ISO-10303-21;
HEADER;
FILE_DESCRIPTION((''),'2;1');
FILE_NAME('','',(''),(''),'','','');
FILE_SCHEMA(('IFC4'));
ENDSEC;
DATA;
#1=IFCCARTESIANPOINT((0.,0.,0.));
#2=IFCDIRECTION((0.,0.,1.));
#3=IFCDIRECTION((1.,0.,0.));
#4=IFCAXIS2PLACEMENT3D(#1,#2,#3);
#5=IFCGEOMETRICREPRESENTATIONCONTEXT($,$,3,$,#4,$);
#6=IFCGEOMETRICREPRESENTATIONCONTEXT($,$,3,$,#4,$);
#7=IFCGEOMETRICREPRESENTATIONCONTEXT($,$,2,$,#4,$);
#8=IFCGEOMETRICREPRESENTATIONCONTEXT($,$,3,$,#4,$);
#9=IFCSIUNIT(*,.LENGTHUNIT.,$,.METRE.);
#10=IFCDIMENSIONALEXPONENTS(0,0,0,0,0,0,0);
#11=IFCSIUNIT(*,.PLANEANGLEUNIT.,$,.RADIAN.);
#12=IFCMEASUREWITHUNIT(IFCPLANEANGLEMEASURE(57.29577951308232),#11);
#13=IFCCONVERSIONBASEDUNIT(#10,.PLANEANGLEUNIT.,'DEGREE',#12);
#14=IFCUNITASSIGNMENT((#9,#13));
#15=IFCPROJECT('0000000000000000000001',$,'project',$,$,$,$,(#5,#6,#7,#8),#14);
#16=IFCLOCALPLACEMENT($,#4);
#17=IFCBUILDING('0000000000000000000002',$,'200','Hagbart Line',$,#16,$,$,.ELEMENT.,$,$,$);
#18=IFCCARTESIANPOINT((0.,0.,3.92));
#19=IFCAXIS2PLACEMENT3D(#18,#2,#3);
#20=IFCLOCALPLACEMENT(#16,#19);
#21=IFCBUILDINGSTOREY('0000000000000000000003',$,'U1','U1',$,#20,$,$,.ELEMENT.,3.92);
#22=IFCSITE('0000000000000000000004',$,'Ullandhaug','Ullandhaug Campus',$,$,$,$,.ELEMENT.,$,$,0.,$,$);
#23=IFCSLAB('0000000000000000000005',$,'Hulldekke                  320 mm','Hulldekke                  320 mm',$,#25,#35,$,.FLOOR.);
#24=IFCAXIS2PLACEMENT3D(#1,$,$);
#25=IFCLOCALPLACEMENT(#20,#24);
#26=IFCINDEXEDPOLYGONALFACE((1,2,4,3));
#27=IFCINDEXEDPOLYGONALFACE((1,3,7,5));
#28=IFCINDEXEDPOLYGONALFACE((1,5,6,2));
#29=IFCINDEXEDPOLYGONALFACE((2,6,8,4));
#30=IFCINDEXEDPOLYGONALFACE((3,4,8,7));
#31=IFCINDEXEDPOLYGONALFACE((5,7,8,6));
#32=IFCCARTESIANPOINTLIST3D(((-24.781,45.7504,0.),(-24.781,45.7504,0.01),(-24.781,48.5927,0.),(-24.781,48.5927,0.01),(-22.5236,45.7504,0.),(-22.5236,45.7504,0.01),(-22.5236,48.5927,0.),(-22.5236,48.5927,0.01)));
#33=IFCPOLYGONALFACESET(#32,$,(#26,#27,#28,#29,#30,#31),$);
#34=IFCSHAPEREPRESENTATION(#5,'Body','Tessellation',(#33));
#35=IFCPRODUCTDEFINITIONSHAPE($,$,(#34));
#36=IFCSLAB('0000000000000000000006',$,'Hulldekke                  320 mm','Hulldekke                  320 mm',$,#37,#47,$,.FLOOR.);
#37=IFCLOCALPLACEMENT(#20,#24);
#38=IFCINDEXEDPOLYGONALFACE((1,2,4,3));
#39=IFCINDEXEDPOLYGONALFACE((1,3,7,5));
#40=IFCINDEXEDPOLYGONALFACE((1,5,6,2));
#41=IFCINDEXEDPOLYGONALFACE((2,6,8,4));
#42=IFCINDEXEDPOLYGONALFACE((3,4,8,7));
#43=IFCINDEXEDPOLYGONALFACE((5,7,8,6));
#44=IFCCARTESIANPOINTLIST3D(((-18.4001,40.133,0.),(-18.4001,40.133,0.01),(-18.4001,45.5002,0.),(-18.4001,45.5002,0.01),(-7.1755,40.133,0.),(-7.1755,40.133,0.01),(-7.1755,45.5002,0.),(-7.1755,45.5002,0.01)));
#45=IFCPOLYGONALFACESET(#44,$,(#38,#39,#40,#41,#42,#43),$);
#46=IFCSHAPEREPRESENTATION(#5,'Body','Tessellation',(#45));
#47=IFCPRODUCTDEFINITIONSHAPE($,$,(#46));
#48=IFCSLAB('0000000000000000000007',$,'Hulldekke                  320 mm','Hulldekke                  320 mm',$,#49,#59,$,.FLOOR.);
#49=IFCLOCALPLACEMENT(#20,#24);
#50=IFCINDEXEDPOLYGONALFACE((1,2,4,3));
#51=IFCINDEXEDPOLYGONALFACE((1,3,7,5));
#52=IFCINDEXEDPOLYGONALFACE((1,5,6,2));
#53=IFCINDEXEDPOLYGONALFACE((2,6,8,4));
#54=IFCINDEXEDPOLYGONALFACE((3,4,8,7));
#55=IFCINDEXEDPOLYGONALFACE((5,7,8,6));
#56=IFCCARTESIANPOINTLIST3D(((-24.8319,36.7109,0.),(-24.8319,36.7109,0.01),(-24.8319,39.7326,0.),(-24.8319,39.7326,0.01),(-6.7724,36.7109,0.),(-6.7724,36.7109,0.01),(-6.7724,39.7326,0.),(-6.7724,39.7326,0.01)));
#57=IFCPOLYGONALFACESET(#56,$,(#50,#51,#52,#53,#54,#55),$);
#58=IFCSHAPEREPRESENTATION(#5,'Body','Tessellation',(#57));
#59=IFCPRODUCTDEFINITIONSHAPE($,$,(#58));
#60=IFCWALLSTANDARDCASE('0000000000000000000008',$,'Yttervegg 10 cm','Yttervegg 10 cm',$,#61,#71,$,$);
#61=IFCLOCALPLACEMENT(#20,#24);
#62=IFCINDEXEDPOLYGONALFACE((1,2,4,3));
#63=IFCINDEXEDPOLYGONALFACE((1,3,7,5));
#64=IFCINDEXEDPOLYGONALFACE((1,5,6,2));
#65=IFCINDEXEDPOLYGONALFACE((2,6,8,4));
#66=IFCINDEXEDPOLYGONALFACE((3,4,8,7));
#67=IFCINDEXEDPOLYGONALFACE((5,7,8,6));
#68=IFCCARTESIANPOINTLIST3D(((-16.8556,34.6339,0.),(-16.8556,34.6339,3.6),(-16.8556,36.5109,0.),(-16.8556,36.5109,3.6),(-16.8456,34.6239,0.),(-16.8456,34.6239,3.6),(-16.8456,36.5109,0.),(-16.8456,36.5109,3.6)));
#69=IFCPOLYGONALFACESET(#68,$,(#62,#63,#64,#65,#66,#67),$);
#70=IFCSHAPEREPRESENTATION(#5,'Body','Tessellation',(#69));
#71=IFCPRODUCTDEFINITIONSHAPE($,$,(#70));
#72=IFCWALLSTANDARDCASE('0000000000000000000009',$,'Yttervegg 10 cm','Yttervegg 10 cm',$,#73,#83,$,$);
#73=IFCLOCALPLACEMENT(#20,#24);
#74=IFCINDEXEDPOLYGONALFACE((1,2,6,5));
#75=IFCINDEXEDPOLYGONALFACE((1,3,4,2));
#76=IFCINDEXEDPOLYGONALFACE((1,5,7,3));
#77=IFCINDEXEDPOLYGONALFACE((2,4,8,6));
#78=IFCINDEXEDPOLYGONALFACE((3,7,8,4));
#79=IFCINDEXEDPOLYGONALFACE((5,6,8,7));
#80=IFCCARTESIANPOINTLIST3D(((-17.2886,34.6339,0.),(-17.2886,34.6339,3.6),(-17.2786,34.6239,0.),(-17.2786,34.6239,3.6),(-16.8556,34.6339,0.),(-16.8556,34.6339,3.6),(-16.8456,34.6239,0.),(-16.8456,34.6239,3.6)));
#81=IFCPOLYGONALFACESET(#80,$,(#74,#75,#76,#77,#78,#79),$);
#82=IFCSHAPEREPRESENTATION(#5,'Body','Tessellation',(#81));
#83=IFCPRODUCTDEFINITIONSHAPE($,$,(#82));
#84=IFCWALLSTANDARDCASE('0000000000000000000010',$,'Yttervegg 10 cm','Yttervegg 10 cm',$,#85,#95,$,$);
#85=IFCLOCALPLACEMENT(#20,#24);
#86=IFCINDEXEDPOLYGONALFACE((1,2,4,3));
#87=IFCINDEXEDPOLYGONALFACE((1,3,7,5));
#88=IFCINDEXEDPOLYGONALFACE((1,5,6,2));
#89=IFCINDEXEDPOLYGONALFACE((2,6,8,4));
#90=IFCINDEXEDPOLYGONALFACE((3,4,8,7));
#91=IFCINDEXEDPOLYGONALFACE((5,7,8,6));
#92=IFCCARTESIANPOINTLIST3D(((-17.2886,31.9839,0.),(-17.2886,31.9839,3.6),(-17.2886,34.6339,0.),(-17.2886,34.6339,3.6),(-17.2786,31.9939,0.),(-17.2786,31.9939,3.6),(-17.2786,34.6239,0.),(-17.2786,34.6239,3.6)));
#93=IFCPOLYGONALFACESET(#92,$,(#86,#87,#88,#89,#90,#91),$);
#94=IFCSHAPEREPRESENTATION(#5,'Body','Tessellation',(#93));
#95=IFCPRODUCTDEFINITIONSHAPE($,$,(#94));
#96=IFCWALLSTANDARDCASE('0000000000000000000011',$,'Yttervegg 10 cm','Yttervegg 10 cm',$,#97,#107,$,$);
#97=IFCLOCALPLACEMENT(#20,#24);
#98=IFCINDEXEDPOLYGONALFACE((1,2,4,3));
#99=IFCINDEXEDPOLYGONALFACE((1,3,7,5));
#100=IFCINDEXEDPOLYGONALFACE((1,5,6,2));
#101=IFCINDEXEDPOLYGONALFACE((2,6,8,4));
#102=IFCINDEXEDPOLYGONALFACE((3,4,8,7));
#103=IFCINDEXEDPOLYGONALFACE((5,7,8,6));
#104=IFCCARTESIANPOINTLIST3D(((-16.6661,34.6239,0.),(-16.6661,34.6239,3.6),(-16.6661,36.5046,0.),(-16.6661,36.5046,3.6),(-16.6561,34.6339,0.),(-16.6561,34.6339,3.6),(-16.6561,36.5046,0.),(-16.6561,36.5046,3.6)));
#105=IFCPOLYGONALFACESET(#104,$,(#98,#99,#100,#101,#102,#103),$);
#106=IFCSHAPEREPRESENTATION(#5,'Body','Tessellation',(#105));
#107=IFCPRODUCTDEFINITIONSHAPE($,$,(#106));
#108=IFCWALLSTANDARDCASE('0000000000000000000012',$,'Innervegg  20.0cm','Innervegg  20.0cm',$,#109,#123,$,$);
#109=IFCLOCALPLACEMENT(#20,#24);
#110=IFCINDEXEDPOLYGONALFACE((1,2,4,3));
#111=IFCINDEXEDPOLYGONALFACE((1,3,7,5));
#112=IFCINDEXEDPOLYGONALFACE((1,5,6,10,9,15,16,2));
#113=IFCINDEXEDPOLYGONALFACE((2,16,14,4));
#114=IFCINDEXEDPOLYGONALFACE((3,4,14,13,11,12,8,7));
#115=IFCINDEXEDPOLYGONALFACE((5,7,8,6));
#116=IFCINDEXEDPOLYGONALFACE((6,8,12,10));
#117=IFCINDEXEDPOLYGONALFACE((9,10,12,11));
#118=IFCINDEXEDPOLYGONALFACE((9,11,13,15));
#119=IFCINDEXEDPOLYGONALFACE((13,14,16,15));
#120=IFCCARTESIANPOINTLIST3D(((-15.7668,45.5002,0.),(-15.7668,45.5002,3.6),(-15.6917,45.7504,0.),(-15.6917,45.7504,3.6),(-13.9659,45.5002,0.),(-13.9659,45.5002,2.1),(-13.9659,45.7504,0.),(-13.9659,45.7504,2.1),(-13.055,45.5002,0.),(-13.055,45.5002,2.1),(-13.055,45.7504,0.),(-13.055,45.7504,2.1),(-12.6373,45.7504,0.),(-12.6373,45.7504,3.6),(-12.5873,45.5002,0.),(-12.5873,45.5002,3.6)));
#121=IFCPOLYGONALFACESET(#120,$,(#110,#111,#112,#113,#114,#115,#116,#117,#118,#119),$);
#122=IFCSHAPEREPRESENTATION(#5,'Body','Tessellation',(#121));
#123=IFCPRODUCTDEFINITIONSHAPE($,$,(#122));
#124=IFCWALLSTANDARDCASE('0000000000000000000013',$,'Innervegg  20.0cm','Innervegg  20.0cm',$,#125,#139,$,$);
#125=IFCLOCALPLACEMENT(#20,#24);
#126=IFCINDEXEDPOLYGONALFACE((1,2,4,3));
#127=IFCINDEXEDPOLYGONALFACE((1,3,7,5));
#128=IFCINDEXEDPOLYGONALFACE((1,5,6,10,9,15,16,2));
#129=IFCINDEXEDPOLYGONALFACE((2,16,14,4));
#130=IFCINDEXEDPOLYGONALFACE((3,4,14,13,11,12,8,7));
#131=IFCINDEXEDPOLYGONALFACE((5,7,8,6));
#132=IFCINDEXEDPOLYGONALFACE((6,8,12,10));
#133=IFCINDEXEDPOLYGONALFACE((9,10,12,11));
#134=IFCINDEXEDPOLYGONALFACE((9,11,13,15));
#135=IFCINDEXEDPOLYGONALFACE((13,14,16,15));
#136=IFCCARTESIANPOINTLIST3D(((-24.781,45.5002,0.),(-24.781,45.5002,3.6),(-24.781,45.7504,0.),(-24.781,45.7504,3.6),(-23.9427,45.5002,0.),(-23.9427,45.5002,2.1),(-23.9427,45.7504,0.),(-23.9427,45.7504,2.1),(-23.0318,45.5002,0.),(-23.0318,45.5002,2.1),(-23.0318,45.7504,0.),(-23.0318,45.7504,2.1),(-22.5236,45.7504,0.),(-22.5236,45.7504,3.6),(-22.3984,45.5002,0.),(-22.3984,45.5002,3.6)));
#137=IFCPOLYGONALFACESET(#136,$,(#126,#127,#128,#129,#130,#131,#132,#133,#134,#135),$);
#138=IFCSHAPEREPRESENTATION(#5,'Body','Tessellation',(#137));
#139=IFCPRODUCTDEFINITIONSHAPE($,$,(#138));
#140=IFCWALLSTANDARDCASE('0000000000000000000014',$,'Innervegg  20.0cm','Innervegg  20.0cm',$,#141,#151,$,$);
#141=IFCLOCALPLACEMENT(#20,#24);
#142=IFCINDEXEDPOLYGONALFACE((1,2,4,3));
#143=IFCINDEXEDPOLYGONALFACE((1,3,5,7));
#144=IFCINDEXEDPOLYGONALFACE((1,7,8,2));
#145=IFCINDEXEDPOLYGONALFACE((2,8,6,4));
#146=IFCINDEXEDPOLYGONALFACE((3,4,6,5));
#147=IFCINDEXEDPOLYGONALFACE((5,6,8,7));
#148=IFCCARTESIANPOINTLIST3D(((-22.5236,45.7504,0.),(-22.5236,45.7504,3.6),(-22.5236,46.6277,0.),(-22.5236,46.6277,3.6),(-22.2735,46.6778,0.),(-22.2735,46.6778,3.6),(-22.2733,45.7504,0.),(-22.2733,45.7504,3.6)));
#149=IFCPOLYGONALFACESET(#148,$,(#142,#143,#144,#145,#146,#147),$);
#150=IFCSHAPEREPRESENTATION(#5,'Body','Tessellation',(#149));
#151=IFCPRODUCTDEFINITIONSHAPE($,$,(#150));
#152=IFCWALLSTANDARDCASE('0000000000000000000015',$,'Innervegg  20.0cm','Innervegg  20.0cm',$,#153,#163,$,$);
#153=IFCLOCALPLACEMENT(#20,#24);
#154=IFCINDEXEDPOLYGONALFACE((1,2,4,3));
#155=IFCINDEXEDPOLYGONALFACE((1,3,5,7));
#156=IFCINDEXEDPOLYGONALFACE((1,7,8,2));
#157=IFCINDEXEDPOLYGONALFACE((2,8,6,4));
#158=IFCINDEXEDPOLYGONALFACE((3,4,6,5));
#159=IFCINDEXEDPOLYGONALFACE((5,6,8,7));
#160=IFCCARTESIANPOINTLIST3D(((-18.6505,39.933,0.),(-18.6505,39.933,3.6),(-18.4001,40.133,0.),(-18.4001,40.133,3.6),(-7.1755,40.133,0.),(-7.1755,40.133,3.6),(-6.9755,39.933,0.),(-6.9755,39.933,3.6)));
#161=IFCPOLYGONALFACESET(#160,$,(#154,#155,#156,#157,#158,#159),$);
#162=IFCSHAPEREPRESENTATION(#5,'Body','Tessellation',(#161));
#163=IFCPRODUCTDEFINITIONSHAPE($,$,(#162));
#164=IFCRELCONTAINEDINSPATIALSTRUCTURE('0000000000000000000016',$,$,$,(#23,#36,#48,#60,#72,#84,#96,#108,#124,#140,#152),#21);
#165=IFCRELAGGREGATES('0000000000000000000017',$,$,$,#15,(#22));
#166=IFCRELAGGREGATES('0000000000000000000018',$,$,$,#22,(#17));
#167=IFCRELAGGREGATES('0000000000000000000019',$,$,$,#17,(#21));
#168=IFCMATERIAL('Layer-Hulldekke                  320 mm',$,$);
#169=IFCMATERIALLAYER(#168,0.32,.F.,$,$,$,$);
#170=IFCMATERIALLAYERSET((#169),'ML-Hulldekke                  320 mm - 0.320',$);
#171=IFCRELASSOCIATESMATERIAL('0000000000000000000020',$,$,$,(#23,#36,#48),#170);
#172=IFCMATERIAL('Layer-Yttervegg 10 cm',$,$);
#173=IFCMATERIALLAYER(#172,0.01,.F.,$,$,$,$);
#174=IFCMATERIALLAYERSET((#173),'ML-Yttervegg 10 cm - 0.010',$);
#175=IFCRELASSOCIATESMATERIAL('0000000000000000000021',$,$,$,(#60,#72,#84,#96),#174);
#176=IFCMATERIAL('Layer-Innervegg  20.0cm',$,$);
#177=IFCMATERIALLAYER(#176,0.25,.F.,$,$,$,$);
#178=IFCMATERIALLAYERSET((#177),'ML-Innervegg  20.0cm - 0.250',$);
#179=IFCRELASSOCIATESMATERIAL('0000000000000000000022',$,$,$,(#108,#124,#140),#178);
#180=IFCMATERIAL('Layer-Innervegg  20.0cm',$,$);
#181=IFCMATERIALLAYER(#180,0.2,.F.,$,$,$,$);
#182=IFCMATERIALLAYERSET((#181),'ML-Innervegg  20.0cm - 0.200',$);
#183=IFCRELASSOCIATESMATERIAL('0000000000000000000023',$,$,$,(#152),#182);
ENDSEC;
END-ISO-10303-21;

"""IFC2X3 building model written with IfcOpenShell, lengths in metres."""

from ifc_helpers import new_model, entity, si_unit, converted_unit, frame, origin_with_axes, place, context, project, spatial, polyline, outline, extrude, material, layer, layer_set, layer_usage, element, save


model = new_model("IFC2X3")

# Units and contexts
context_of_model_1 = context(None, 3, world=origin_with_axes())
context_of_model_2 = context(None, 3, world=origin_with_axes())
context_of_model_3 = context(None, 2, world=origin_with_axes())
context_of_model_4 = context(None, 3, world=origin_with_axes())
ifc_project = project(units=[si_unit("LENGTHUNIT", "METRE"), converted_unit("PLANEANGLEUNIT", "DEGREE", entity("IfcPlaneAngleMeasure", 57.29577951308232), si_unit("PLANEANGLEUNIT", "RADIAN"), dimensions=[0, 0, 0, 0, 0, 0, 0])], contexts=[context_of_model_1, context_of_model_2, context_of_model_3, context_of_model_4])

# Site, building, storey
site = spatial("IfcSite", under=ifc_project, Name="Ullandhaug", Description="Ullandhaug Campus", CompositionType="ELEMENT", RefElevation=0.0)
building_placement = place(None, origin_with_axes())
building = spatial("IfcBuilding", under=site, at=building_placement, Name="200", Description="Hagbart Line", CompositionType="ELEMENT")
storey_placement = place(building_placement, frame((0.0, 0.0, 3.92), z_axis=(0.0, 0.0, 1.0), x_axis=(1.0, 0.0, 0.0)))
storey = spatial("IfcBuildingStorey", under=building, at=storey_placement, Name="U1", Description="U1", CompositionType="ELEMENT", Elevation=3.92)

# Slabs
ifc_material_1 = material(Name="Layer-Hulldekke                  320 mm")
ifc_layer_1 = layer(ifc_material_1, 0.32, ventilated=False)
ifc_layer_set_1 = layer_set([ifc_layer_1], Name="ML-Hulldekke                  320 mm - 0.320")
ifc_layer_usage_1 = layer_usage(ifc_layer_set_1, "AXIS2", "POSITIVE", 0.0)
slab_1_placement = place(storey_placement, frame((-24.781, 45.7504, 0.0), z_axis=(0.0, 0.0, 1.0), x_axis=(1.0, 0.0, 0.0)))
element("IfcSlab", 1, at=slab_1_placement, inside=storey, material=ifc_layer_usage_1, Name="Hulldekke                  320 mm", Description="Hulldekke                  320 mm", PredefinedType="FLOOR", context=context_of_model_1, shape_type="SweptSolid", body=[
    extrude(outline(polyline([(0.0, 0.0), (2.2574, 0.0), (2.2574, 2.8423), (0.0, 2.8423), (0.0, 0.0)])), origin_with_axes(), (0.0, 0.0, 1.0), 0.01),
])
slab_2_placement = place(storey_placement, frame((-18.4001, 40.133, 0.0), z_axis=(0.0, 0.0, 1.0), x_axis=(1.0, 0.0, 0.0)))
element("IfcSlab", 2, at=slab_2_placement, inside=storey, material=ifc_layer_usage_1, Name="Hulldekke                  320 mm", Description="Hulldekke                  320 mm", PredefinedType="FLOOR", context=context_of_model_1, shape_type="SweptSolid", body=[
    extrude(outline(polyline([(0.0, 0.0), (11.2246, 0.0), (11.2246, 5.3672), (0.0, 5.3672), (0.0, 0.0)])), origin_with_axes(), (0.0, 0.0, 1.0), 0.01),
])
slab_3_placement = place(storey_placement, frame((-24.8319, 36.7109, 0.0), z_axis=(0.0, 0.0, 1.0), x_axis=(1.0, 0.0, 0.0)))
element("IfcSlab", 3, at=slab_3_placement, inside=storey, material=ifc_layer_usage_1, Name="Hulldekke                  320 mm", Description="Hulldekke                  320 mm", PredefinedType="FLOOR", context=context_of_model_1, shape_type="SweptSolid", body=[
    extrude(outline(polyline([(0.0, 0.0), (18.0596, 0.0), (18.0596, 3.0216), (0.0, 3.0216), (0.0, 0.0)])), origin_with_axes(), (0.0, 0.0, 1.0), 0.01),
])

# Walls
ifc_material_2 = material(Name="Layer-Yttervegg 10 cm")
ifc_layer_2 = layer(ifc_material_2, 0.01, ventilated=False)
ifc_layer_set_2 = layer_set([ifc_layer_2], Name="ML-Yttervegg 10 cm - 0.010")
ifc_layer_usage_2 = layer_usage(ifc_layer_set_2, "AXIS2", "POSITIVE", 0.0)
wall_1_placement = place(storey_placement, frame((-16.8556, 36.5109, 0.0), z_axis=(0.0, 0.0, 1.0), x_axis=(0.0, -1.0, 0.0)))
element("IfcWallStandardCase", 4, at=wall_1_placement, inside=storey, material=ifc_layer_usage_2, Name="Yttervegg 10 cm", Description="Yttervegg 10 cm", context=context_of_model_1, shape_type="SweptSolid", body=[
    extrude(outline(polyline([(0.0, 0.0), (1.877, 0.0), (1.887, 0.01), (0.0, 0.01), (0.0, 0.0)])), frame((0.0, 0.0, 0.0), z_axis=(0.0, 0.0, 1.0), x_axis=(1.0, 0.0, 0.0)), (0.0, 0.0, 1.0), 3.6),
])
wall_2_placement = place(storey_placement, frame((-16.8556, 34.6339, 0.0), z_axis=(0.0, 0.0, 1.0), x_axis=(-1.0, 0.0, 0.0)))
element("IfcWallStandardCase", 5, at=wall_2_placement, inside=storey, material=ifc_layer_usage_2, Name="Yttervegg 10 cm", Description="Yttervegg 10 cm", context=context_of_model_1, shape_type="SweptSolid", body=[
    extrude(outline(polyline([(0.0, 0.0), (0.433, 0.0), (0.423, 0.01), (-0.01, 0.01), (0.0, 0.0)])), frame((0.0, 0.0, 0.0), z_axis=(0.0, 0.0, 1.0), x_axis=(1.0, 0.0, 0.0)), (0.0, 0.0, 1.0), 3.6),
])
wall_3_placement = place(storey_placement, frame((-17.2886, 34.6339, 0.0), z_axis=(0.0, 0.0, 1.0), x_axis=(0.0, -1.0, 0.0)))
element("IfcWallStandardCase", 6, at=wall_3_placement, inside=storey, material=ifc_layer_usage_2, Name="Yttervegg 10 cm", Description="Yttervegg 10 cm", context=context_of_model_1, shape_type="SweptSolid", body=[
    extrude(outline(polyline([(0.0, 0.0), (2.65, 0.0), (2.64, 0.01), (0.01, 0.01), (0.0, 0.0)])), frame((0.0, 0.0, 0.0), z_axis=(0.0, 0.0, 1.0), x_axis=(1.0, 0.0, 0.0)), (0.0, 0.0, 1.0), 3.6),
])
wall_4_placement = place(storey_placement, frame((-16.6561, 34.6339, 0.0), z_axis=(0.0, 0.0, 1.0), x_axis=(0.0, 1.0, 0.0)))
element("IfcWallStandardCase", 7, at=wall_4_placement, inside=storey, material=ifc_layer_usage_2, Name="Yttervegg 10 cm", Description="Yttervegg 10 cm", context=context_of_model_1, shape_type="SweptSolid", body=[
    extrude(outline(polyline([(0.0, 0.0), (1.8707, 0.0), (1.8707, 0.01), (-0.01, 0.01), (0.0, 0.0)])), frame((0.0, 0.0, 0.0), z_axis=(0.0, 0.0, 1.0), x_axis=(1.0, 0.0, 0.0)), (0.0, 0.0, 1.0), 3.6),
])

# Walls, openings
ifc_material_3 = material(Name="Layer-Innervegg  20.0cm")
ifc_layer_3 = layer(ifc_material_3, 0.25, ventilated=False)
ifc_layer_set_3 = layer_set([ifc_layer_3], Name="ML-Innervegg  20.0cm - 0.250")
ifc_layer_usage_3 = layer_usage(ifc_layer_set_3, "AXIS2", "POSITIVE", 0.0)
wall_5_placement = place(storey_placement, frame((-15.7668, 45.5002, 0.0), z_axis=(0.0, 0.0, 1.0), x_axis=(1.0, 0.0, 0.0)))
wall_5 = element("IfcWallStandardCase", 8, at=wall_5_placement, inside=storey, material=ifc_layer_usage_3, Name="Innervegg  20.0cm", Description="Innervegg  20.0cm", context=context_of_model_1, shape_type="SweptSolid", body=[
    extrude(outline(polyline([(0.0, 0.0), (3.1795, 0.0), (3.1294, 0.2502), (0.0751, 0.2502), (0.0, 0.0)])), origin_with_axes(), (0.0, 0.0, 1.0), 3.6),
])
opening_1_placement = place(wall_5_placement, frame((1.8009, 0.2502, 0.0), z_axis=(0.0, 0.0, 1.0), x_axis=(1.0, 0.0, 0.0)))
element("IfcOpeningElement", 9, at=opening_1_placement, cuts=wall_5, context=context_of_model_1, shape_type="SweptSolid", body=[
    extrude(outline(polyline([(0.0, 0.0), (2.1, 0.0), (2.1, 0.9109), (0.0, 0.9109), (0.0, 0.0)])), frame((0.0, 0.0, 0.0), z_axis=(0.0, 1.0, 0.0), x_axis=(0.0, 0.0, 1.0)), (0.0, 0.0, -1.0), 0.2502),
])
wall_6_placement = place(storey_placement, frame((-24.781, 45.5002, 0.0), z_axis=(0.0, 0.0, 1.0), x_axis=(1.0, 0.0, 0.0)))
wall_6 = element("IfcWallStandardCase", 10, at=wall_6_placement, inside=storey, material=ifc_layer_usage_3, Name="Innervegg  20.0cm", Description="Innervegg  20.0cm", context=context_of_model_1, shape_type="SweptSolid", body=[
    extrude(outline(polyline([(0.0, 0.0), (2.3826, 0.0), (2.2574, 0.2502), (0.0, 0.2502), (0.0, 0.0)])), origin_with_axes(), (0.0, 0.0, 1.0), 3.6),
])
opening_2_placement = place(wall_6_placement, frame((0.8383, 0.2502, 0.0), z_axis=(0.0, 0.0, 1.0), x_axis=(1.0, 0.0, 0.0)))
element("IfcOpeningElement", 11, at=opening_2_placement, cuts=wall_6, context=context_of_model_1, shape_type="SweptSolid", body=[
    extrude(outline(polyline([(0.0, 0.0), (2.1, 0.0), (2.1, 0.9109), (0.0, 0.9109), (0.0, 0.0)])), frame((0.0, 0.0, 0.0), z_axis=(0.0, 1.0, 0.0), x_axis=(0.0, 0.0, 1.0)), (0.0, 0.0, -1.0), 0.2502),
])

# Walls
wall_7_placement = place(storey_placement, frame((-22.2733, 45.7504, 0.0), z_axis=(0.0, 0.0, 1.0), x_axis=(-0.000228, 1.0, 0.0)))
element("IfcWallStandardCase", 12, at=wall_7_placement, inside=storey, material=ifc_layer_usage_3, Name="Innervegg  20.0cm", Description="Innervegg  20.0cm", context=context_of_model_1, shape_type="SweptSolid", body=[
    extrude(outline(polyline([(0.0, 0.0), (0.9274, 0.0), (0.8773, 0.25), (0.0001, 0.2502), (0.0, 0.0)])), frame((0.0, 0.0, 0.0), z_axis=(0.0, 0.0, 1.0), x_axis=(1.0, 0.0, 0.0)), (0.0, 0.0, 1.0), 3.6),
])
ifc_material_4 = material(Name="Layer-Innervegg  20.0cm")
ifc_layer_4 = layer(ifc_material_4, 0.2, ventilated=False)
ifc_layer_set_4 = layer_set([ifc_layer_4], Name="ML-Innervegg  20.0cm - 0.200")
ifc_layer_usage_4 = layer_usage(ifc_layer_set_4, "AXIS2", "POSITIVE", 0.0)
wall_8_placement = place(storey_placement, frame((-18.6505, 39.933, 0.0), z_axis=(0.0, 0.0, 1.0), x_axis=(1.0, 0.0, 0.0)))
element("IfcWallStandardCase", 13, at=wall_8_placement, inside=storey, material=ifc_layer_usage_4, Name="Innervegg  20.0cm", Description="Innervegg  20.0cm", context=context_of_model_1, shape_type="SweptSolid", body=[
    extrude(outline(polyline([(0.0, 0.0), (11.6751, 0.0), (11.4751, 0.2), (0.2505, 0.2), (0.0, 0.0)])), origin_with_axes(), (0.0, 0.0, 1.0), 3.6),
])

save(model, "model.ifc")
